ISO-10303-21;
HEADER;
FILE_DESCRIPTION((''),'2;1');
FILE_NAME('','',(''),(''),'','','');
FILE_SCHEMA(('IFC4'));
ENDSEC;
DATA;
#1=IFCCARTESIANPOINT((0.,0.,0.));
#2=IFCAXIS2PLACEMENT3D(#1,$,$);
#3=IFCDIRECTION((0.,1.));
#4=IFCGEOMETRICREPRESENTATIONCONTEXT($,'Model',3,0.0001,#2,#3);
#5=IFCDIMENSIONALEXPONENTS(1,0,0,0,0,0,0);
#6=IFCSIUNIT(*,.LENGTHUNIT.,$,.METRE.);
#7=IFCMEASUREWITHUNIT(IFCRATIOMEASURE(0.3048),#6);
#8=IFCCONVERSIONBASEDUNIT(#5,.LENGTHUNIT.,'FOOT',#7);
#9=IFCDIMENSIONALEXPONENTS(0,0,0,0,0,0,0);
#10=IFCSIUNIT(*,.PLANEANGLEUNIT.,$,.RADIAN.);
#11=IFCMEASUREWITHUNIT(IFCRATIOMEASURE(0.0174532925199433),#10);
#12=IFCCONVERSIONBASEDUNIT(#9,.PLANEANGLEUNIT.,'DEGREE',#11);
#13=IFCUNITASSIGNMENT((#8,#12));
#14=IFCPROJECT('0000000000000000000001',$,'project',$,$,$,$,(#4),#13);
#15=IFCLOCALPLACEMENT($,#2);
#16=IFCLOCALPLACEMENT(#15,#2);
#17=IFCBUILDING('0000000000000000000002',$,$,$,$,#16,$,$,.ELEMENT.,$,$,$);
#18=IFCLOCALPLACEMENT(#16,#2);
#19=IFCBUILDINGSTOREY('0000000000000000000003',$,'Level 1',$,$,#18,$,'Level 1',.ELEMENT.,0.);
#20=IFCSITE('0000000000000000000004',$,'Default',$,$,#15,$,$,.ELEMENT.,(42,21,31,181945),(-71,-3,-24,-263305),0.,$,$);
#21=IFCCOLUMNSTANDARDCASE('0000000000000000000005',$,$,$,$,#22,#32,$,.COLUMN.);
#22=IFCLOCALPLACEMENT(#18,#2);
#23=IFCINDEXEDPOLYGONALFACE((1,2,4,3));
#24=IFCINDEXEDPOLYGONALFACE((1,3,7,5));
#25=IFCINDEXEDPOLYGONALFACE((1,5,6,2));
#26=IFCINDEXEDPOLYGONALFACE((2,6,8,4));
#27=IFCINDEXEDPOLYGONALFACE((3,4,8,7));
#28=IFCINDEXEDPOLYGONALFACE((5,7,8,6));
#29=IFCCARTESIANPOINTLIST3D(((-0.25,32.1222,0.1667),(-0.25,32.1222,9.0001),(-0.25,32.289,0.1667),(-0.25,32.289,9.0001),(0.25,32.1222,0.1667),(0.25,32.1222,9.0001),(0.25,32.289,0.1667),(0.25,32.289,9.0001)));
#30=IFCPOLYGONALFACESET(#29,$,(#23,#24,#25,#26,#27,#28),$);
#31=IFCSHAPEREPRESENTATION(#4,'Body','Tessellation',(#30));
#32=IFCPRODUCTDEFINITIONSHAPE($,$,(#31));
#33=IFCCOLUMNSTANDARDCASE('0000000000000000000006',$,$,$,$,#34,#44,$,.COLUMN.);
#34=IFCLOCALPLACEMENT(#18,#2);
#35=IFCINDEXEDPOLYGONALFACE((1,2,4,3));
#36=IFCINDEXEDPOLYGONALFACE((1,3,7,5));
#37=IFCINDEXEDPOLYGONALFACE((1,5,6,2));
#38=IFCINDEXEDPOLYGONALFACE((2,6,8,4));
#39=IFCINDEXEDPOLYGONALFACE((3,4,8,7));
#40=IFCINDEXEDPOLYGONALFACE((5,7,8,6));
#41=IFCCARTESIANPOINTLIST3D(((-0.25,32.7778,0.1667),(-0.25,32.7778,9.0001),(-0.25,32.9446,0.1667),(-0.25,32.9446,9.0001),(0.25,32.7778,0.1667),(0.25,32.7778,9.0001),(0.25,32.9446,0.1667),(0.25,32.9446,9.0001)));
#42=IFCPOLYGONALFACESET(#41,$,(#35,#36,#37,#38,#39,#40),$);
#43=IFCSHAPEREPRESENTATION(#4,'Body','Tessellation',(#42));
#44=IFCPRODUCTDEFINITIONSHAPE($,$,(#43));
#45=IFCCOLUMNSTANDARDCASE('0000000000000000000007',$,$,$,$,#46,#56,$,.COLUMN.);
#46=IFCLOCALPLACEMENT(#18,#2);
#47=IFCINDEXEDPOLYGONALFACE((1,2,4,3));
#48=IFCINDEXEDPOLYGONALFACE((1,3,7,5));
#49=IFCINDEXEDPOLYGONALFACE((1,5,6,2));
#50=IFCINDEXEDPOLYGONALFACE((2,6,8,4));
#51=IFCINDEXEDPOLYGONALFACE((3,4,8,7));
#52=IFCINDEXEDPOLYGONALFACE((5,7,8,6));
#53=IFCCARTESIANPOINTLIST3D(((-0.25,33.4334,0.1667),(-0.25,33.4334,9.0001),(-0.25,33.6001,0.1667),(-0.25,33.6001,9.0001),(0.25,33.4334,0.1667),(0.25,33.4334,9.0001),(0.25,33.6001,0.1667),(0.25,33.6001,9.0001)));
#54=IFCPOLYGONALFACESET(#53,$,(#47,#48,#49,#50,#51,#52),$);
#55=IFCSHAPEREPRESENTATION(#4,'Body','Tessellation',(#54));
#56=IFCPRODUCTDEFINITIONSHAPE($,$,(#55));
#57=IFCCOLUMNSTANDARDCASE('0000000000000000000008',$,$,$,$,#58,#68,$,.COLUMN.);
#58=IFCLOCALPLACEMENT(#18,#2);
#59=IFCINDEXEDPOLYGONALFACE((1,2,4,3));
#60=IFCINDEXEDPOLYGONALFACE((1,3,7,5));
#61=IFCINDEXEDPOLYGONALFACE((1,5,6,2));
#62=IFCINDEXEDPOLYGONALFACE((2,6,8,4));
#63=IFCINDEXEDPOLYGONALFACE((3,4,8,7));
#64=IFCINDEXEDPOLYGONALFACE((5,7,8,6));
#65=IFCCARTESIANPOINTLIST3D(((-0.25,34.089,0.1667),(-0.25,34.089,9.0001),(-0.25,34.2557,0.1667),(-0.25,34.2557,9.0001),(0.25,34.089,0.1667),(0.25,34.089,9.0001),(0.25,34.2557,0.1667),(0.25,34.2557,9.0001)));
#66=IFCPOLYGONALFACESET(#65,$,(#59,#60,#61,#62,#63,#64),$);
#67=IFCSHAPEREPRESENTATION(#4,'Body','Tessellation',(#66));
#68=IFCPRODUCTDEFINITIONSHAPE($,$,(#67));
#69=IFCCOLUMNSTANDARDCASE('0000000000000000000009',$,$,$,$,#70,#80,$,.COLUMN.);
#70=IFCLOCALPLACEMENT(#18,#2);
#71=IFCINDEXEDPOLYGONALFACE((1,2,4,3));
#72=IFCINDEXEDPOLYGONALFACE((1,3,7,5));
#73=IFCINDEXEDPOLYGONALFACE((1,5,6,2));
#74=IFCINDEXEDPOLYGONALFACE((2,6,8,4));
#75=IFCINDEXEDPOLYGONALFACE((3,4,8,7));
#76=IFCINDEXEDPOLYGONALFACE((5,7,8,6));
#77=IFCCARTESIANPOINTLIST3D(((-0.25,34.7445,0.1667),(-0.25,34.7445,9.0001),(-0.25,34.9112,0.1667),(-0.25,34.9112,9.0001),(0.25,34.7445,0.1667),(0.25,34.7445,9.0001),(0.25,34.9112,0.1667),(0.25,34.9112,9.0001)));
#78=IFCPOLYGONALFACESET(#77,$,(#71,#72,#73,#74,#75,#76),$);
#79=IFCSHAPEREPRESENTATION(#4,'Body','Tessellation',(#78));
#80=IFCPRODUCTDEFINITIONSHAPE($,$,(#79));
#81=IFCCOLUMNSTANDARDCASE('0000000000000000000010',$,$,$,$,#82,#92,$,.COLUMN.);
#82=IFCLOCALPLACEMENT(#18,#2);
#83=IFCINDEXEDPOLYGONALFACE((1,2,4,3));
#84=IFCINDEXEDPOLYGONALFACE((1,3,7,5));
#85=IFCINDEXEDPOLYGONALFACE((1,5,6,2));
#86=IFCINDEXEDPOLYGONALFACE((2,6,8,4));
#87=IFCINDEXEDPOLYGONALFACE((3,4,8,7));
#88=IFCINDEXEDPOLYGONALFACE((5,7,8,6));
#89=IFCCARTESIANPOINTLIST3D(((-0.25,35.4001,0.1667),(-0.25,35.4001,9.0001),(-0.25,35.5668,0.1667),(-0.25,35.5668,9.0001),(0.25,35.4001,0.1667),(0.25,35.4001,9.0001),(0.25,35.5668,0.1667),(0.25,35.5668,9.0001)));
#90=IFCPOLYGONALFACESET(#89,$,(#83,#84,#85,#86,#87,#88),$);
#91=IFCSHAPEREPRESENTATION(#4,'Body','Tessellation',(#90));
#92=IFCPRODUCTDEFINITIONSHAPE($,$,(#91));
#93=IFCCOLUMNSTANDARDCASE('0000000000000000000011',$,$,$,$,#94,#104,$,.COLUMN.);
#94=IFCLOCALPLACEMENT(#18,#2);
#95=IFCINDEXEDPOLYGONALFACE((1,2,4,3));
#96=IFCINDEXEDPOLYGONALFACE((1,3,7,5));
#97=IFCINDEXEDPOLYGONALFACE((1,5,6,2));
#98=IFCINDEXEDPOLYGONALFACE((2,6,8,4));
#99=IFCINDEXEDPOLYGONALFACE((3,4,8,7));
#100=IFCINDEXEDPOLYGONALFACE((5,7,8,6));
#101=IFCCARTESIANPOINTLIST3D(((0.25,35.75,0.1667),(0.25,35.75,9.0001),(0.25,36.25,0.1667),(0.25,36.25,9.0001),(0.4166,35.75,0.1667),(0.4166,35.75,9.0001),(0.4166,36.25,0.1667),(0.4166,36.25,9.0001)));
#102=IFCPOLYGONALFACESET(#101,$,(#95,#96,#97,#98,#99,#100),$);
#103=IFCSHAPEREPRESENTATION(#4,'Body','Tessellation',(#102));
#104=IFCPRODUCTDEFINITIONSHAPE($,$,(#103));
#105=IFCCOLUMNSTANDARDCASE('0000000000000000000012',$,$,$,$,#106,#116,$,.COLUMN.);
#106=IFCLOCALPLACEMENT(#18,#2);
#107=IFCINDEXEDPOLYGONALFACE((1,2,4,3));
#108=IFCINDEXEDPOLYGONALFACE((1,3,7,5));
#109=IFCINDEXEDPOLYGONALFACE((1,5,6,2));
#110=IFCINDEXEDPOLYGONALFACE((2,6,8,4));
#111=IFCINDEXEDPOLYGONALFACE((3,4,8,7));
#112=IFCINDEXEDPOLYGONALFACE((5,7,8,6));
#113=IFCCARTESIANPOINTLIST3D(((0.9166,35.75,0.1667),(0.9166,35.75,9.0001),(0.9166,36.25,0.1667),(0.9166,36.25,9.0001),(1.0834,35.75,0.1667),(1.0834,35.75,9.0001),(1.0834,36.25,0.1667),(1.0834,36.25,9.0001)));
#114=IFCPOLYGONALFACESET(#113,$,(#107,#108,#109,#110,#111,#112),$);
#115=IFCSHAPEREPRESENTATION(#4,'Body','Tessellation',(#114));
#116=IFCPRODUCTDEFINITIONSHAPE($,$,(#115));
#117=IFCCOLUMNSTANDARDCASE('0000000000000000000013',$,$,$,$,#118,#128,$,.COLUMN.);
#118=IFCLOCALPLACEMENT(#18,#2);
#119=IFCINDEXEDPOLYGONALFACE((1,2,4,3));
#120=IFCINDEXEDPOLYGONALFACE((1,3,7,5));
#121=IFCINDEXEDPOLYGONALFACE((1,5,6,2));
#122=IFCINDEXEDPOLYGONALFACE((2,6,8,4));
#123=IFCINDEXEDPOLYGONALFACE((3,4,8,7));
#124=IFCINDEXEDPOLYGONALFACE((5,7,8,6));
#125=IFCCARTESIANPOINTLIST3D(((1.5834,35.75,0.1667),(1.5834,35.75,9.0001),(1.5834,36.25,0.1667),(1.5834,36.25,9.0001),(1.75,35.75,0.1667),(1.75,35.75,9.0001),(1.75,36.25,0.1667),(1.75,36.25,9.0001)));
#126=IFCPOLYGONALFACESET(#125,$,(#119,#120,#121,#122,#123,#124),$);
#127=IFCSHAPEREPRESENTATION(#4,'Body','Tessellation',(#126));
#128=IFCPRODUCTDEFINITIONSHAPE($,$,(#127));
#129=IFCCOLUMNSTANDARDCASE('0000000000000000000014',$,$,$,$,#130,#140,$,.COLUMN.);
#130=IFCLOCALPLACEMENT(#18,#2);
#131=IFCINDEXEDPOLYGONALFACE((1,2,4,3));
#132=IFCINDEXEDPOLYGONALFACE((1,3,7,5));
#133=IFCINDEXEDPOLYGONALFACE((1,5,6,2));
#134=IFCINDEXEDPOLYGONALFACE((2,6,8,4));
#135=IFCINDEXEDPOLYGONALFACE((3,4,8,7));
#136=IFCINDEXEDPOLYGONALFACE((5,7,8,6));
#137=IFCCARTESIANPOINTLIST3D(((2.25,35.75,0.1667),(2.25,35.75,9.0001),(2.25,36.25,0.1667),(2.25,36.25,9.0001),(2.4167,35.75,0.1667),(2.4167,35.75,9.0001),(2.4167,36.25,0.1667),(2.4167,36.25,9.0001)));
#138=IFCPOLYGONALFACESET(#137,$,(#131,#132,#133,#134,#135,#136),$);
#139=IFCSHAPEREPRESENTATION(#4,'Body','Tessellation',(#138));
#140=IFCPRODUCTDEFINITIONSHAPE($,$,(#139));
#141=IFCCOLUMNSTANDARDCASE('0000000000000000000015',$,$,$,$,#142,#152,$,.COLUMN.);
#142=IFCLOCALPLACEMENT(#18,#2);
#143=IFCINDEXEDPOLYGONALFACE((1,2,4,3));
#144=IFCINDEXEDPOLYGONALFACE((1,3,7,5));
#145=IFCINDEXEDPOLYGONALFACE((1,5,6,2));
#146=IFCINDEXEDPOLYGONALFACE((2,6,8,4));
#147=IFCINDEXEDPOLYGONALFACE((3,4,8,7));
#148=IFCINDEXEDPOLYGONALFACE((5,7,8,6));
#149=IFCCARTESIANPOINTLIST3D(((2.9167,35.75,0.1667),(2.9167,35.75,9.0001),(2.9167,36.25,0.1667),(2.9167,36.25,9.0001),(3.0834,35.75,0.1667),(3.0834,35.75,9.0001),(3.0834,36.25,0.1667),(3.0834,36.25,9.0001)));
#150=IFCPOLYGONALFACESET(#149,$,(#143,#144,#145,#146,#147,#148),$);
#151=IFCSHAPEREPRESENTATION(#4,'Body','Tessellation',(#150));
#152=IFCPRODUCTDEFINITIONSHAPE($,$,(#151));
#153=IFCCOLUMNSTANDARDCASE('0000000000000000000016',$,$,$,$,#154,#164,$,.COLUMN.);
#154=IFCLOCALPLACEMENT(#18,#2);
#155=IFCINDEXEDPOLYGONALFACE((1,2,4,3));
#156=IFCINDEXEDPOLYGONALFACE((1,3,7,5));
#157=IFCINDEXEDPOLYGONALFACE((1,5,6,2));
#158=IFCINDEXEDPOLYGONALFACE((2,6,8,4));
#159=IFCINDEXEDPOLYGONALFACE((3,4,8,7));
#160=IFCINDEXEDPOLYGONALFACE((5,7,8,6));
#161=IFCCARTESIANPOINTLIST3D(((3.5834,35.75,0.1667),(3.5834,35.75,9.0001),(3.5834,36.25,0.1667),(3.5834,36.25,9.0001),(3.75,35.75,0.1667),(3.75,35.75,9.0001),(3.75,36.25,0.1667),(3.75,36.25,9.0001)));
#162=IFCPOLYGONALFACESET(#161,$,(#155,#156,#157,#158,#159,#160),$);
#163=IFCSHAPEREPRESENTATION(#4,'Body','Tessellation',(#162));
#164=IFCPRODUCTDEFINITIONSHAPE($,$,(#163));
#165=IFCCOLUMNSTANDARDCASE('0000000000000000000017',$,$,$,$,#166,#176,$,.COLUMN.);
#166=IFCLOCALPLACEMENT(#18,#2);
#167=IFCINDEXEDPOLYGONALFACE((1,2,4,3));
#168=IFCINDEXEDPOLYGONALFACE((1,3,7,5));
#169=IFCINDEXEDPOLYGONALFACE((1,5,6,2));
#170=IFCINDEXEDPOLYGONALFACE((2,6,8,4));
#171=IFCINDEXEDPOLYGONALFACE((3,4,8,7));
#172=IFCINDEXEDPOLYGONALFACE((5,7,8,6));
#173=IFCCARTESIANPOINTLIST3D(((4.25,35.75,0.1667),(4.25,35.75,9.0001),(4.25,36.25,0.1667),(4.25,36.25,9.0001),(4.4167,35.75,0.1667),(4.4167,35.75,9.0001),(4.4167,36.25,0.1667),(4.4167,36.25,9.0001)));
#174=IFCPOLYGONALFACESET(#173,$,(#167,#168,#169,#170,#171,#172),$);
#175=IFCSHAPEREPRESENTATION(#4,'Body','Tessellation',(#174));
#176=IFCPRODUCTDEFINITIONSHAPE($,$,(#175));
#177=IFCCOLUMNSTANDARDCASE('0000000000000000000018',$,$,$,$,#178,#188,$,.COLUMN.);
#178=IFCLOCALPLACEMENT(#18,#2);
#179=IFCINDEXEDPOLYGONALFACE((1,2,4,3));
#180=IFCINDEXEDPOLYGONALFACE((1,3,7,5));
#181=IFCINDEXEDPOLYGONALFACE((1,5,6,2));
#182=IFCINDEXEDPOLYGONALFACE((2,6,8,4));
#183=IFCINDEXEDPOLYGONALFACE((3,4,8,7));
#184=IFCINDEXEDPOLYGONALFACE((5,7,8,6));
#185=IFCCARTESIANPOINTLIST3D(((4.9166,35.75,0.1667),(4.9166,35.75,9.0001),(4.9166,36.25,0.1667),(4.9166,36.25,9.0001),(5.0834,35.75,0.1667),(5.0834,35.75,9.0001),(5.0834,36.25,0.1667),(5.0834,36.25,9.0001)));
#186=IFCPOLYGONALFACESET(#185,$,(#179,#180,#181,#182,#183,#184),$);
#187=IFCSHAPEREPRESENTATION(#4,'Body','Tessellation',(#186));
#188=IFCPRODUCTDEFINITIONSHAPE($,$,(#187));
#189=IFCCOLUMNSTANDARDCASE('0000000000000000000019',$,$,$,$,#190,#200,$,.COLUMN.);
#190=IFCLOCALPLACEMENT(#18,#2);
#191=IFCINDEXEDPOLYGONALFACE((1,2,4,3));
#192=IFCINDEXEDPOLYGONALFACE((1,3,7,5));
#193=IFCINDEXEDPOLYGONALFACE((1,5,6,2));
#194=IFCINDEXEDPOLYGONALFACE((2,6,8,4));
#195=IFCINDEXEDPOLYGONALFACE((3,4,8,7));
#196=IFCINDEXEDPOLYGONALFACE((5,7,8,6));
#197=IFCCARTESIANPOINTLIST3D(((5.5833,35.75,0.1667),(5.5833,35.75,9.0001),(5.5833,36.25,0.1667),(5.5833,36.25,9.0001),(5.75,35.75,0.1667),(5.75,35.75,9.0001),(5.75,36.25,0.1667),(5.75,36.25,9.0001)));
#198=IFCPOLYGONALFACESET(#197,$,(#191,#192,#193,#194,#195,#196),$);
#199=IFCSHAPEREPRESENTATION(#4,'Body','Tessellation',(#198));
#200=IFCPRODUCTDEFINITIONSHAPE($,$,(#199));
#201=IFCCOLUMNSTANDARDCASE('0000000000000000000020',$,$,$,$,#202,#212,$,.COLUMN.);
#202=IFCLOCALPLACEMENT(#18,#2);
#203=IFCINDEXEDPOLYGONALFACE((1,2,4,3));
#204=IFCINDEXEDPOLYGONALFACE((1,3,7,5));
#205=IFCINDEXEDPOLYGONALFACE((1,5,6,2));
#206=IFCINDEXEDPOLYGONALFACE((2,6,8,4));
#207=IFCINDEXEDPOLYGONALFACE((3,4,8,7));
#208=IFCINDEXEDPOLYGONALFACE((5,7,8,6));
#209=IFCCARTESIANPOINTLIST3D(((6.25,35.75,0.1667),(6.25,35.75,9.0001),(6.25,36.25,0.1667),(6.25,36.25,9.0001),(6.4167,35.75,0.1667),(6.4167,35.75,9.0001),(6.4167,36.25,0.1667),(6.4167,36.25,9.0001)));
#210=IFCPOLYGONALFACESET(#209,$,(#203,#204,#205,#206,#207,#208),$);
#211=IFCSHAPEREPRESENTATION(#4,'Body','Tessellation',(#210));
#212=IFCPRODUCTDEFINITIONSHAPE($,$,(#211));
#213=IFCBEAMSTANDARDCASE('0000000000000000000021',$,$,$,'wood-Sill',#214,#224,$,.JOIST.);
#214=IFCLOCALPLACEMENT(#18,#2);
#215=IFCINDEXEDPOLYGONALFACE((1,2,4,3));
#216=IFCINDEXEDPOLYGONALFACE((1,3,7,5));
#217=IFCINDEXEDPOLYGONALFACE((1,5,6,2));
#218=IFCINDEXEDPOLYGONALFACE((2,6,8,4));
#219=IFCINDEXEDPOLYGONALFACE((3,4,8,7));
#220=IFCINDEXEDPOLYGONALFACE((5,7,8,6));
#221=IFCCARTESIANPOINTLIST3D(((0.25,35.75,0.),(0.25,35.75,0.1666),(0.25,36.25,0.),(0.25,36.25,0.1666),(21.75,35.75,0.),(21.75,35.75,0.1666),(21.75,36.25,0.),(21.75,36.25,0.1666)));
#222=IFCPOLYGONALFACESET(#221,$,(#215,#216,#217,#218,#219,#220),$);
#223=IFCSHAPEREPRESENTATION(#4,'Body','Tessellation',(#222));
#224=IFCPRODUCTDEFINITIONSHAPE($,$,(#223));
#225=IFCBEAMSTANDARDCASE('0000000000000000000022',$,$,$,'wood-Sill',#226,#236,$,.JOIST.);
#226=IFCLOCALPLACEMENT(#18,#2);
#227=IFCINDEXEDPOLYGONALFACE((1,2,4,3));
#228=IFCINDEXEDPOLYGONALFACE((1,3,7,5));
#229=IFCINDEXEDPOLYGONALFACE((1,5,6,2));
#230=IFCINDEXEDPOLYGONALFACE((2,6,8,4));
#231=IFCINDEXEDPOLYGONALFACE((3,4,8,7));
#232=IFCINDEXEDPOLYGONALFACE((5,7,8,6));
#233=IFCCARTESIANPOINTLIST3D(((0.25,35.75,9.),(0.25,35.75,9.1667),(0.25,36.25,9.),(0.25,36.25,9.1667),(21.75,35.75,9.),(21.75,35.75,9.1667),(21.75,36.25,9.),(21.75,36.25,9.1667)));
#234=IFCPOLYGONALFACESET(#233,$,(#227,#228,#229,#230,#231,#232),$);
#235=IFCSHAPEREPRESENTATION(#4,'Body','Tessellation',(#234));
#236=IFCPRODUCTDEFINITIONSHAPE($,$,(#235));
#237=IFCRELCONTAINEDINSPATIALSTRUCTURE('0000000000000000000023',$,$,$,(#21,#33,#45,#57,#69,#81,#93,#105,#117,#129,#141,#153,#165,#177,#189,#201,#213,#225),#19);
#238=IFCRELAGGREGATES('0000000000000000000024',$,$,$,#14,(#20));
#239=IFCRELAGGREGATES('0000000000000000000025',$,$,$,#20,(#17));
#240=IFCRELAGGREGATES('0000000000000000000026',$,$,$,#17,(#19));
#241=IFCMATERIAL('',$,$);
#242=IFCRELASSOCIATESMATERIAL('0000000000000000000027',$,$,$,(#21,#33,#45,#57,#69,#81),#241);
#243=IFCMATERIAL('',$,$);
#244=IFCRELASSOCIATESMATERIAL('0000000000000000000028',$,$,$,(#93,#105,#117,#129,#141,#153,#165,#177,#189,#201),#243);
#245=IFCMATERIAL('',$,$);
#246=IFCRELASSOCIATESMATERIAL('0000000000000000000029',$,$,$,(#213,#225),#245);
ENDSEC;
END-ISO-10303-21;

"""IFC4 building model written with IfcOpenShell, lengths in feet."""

from ifc_helpers import new_model, entity, si_unit, converted_unit, direction, frame, origin, origin_with_axes, place, context, project, spatial, rectangle, extrude, material, element, save


model = new_model("IFC4")

# Units and contexts
model_context = context("Model", 3, precision=0.0001, world=origin(), true_north=direction((0.0, 1.0)))
ifc_project = project(units=[converted_unit("LENGTHUNIT", "FOOT", entity("IfcRatioMeasure", 0.3048), si_unit("LENGTHUNIT", "METRE"), dimensions=[1, 0, 0, 0, 0, 0, 0]), converted_unit("PLANEANGLEUNIT", "DEGREE", entity("IfcRatioMeasure", 0.0174532925199433), si_unit("PLANEANGLEUNIT", "RADIAN"), dimensions=[0, 0, 0, 0, 0, 0, 0])], contexts=[model_context])

# Site, building, storey
site_placement = place(None, origin())
site = spatial("IfcSite", under=ifc_project, at=site_placement, Name="Default", CompositionType="ELEMENT", RefLatitude=(42, 21, 31, 181945), RefLongitude=(-71, -3, -24, -263305), RefElevation=0.0)
building_placement = place(site_placement, origin())
building = spatial("IfcBuilding", under=site, at=building_placement, CompositionType="ELEMENT")
storey_placement = place(building_placement, origin())
storey = spatial("IfcBuildingStorey", under=building, at=storey_placement, Name="Level 1", LongName="Level 1", CompositionType="ELEMENT", Elevation=0.0)

# Columns
ifc_material_1 = material(Name="")
placement_1 = place(storey_placement, frame((0.0, -0.25, 0.0), z_axis=(0.0, 0.0, 1.0), x_axis=(0.0, 1.0, 0.0)))
for number, where, z_axis, x_axis in (
    (1, (32.4556, 0.0, 0.1667), (0.0, 0.0, 1.0), (1.0, 0.0, 0.0)),
    (2, (33.1112, 0.0, 0.1667), (0.0, 0.0, 1.0), (1.0, 0.0, 0.0)),
    (3, (33.7667, 0.0, 0.1667), (0.0, 0.0, 1.0), (1.0, 0.0, 0.0)),
    (4, (34.4223, 0.0, 0.1667), (0.0, 0.0, 1.0), (1.0, 0.0, 0.0)),
    (5, (35.0778, 0.0, 0.1667), (0.0, 0.0, 1.0), (1.0, 0.0, 0.0)),
    (6, (35.7334, 0.0, 0.1667), (0.0, 0.0, 1.0), (1.0, 0.0, 0.0)),
):
    element("IfcColumnStandardCase", number, at=place(placement_1, frame(where, z_axis=z_axis, x_axis=x_axis)), inside=storey, material=ifc_material_1, PredefinedType="COLUMN", context=model_context, shape_type="SweptSolid", body=[
        extrude(rectangle(XDim=0.1667, YDim=0.5), origin(), (0.0, 0.0, 1.0), 8.8334),
    ])
ifc_material_2 = material(Name="")
placement_2 = place(storey_placement, frame((0.25, 36.0, 0.0)))
for number, where, z_axis, x_axis in (
    (7, (0.0833, 0.0, 0.1667), (0.0, 0.0, 1.0), (1.0, 0.0, 0.0)),
    (8, (0.75, 0.0, 0.1667), (0.0, 0.0, 1.0), (1.0, 0.0, 0.0)),
    (9, (1.4167, 0.0, 0.1667), (0.0, 0.0, 1.0), (1.0, 0.0, 0.0)),
    (10, (2.0833, 0.0, 0.1667), (0.0, 0.0, 1.0), (1.0, 0.0, 0.0)),
    (11, (2.75, 0.0, 0.1667), (0.0, 0.0, 1.0), (1.0, 0.0, 0.0)),
    (12, (3.4167, 0.0, 0.1667), (0.0, 0.0, 1.0), (1.0, 0.0, 0.0)),
    (13, (4.0833, 0.0, 0.1667), (0.0, 0.0, 1.0), (1.0, 0.0, 0.0)),
    (14, (4.75, 0.0, 0.1667), (0.0, 0.0, 1.0), (1.0, 0.0, 0.0)),
    (15, (5.4167, 0.0, 0.1667), (0.0, 0.0, 1.0), (1.0, 0.0, 0.0)),
    (16, (6.0833, 0.0, 0.1667), (0.0, 0.0, 1.0), (1.0, 0.0, 0.0)),
):
    element("IfcColumnStandardCase", number, at=place(placement_2, frame(where, z_axis=z_axis, x_axis=x_axis)), inside=storey, material=ifc_material_2, PredefinedType="COLUMN", context=model_context, shape_type="SweptSolid", body=[
        extrude(rectangle(XDim=0.1667, YDim=0.5), origin(), (0.0, 0.0, 1.0), 8.8334),
    ])

# Beams
ifc_material_3 = material(Name="")
for number, where, z_axis, x_axis in (
    (17, (0.0, 0.0, 0.0833), (1.0, 0.0, 0.0), (0.0, 0.0, 1.0)),
    (18, (0.0, 0.0, 9.0834), (1.0, 0.0, 0.0), (0.0, 0.0, 1.0)),
):
    element("IfcBeamStandardCase", number, at=place(placement_2, frame(where, z_axis=z_axis, x_axis=x_axis)), inside=storey, material=ifc_material_3, ObjectType="wood-Sill", PredefinedType="JOIST", context=model_context, shape_type="SweptSolid", body=[
        extrude(rectangle(XDim=0.1667, YDim=0.5), origin_with_axes(), (0.0, 0.0, 1.0), 21.5),
    ])

save(model, "model.ifc")
